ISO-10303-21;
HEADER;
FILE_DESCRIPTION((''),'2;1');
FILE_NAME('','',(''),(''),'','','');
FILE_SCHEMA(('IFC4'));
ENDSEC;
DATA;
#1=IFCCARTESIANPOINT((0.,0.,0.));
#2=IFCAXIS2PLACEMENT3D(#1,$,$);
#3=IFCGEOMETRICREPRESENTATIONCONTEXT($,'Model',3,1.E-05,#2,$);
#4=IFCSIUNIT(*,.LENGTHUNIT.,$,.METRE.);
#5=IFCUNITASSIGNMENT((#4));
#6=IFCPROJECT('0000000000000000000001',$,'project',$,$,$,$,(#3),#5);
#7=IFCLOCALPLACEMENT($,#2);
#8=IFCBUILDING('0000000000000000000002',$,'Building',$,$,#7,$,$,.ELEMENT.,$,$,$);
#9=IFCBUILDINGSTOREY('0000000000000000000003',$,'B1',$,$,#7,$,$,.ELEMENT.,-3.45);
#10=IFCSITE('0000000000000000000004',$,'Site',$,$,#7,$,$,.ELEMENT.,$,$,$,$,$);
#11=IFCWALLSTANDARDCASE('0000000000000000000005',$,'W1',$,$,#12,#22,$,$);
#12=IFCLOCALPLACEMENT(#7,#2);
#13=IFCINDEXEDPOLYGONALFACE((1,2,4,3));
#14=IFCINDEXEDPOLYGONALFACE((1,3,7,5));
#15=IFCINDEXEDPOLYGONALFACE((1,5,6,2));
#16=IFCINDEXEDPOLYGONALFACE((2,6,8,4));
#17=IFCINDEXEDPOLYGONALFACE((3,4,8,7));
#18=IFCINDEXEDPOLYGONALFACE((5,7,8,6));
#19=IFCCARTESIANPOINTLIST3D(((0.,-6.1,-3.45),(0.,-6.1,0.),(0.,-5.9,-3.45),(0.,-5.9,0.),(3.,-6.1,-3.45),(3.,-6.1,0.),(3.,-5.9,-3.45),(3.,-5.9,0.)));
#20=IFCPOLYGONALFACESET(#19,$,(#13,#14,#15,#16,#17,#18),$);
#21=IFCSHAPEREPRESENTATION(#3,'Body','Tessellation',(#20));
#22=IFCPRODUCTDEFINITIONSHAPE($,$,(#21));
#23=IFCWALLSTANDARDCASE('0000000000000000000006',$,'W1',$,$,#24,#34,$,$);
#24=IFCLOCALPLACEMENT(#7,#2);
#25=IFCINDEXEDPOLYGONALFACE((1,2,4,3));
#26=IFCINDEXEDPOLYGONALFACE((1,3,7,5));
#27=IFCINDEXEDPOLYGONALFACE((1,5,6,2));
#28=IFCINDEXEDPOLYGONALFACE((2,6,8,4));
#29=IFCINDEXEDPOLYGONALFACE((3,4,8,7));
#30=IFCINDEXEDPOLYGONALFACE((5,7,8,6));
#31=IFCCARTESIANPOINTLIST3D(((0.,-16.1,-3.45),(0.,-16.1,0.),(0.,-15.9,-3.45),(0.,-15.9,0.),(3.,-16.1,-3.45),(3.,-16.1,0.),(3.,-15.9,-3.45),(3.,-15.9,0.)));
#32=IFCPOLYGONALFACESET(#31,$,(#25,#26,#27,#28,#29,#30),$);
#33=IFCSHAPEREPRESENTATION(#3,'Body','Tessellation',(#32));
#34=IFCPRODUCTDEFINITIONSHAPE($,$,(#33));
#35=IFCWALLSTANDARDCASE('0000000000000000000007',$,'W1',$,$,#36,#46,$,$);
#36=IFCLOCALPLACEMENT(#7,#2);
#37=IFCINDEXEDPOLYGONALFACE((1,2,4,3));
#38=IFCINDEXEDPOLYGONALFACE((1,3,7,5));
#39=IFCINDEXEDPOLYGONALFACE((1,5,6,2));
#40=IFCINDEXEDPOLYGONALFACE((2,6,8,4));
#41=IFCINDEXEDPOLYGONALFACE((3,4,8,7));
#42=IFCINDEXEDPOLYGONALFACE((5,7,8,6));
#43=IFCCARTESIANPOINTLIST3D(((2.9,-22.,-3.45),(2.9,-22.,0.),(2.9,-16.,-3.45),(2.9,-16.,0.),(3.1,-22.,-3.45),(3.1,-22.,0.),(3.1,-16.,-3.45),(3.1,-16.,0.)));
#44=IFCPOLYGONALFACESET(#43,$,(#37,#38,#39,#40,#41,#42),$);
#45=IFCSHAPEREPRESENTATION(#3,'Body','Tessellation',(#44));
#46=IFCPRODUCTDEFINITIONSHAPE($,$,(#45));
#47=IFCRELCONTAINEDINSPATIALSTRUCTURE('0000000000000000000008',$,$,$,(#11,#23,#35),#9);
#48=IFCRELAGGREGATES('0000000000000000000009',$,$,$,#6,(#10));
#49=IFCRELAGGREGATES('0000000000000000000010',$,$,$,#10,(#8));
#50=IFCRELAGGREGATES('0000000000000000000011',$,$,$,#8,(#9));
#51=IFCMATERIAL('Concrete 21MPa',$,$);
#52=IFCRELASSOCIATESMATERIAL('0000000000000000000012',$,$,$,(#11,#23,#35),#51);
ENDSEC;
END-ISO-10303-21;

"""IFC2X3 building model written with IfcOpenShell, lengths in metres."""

from ifc_helpers import new_model, si_unit, frame, origin, origin_2d, place, context, project, spatial, rectangle, extrude, material, element, save


model = new_model("IFC2X3")

# Units and contexts
model_context = context("Model", 3, precision=1e-05, world=origin())
ifc_project = project(units=[si_unit("LENGTHUNIT", "METRE")], contexts=[model_context])

# Site, building, storey
placement = place(None, origin())
site = spatial("IfcSite", under=ifc_project, at=placement, Name="Site", CompositionType="ELEMENT")
building = spatial("IfcBuilding", under=site, at=placement, Name="Building", CompositionType="ELEMENT")
storey = spatial("IfcBuildingStorey", under=building, at=placement, Name="B1", CompositionType="ELEMENT", Elevation=-3.45)

# Shared definitions
ifc_material = material(Name="Concrete 21MPa")

# Walls
for number, where, name in (
    (1, (1.5, -6.0, -3.45), "W1"),
    (2, (1.5, -16.0, -3.45), "W1"),
):
    element("IfcWallStandardCase", number, at=place(None, frame(where)), inside=storey, material=ifc_material, Name=name, context=model_context, shape_type="SweptSolid", body=[
        extrude(rectangle(XDim=3.0, YDim=0.2, at=origin_2d()), origin(), (0.0, 0.0, 1.0), 3.45),
    ])
wall_1_placement = place(None, frame((3.0, -19.0, -3.45)))
element("IfcWallStandardCase", 3, at=wall_1_placement, inside=storey, material=ifc_material, Name="W1", context=model_context, shape_type="SweptSolid", body=[
    extrude(rectangle(XDim=0.2, YDim=6.0, at=origin_2d()), origin(), (0.0, 0.0, 1.0), 3.45),
])

save(model, "model.ifc")
